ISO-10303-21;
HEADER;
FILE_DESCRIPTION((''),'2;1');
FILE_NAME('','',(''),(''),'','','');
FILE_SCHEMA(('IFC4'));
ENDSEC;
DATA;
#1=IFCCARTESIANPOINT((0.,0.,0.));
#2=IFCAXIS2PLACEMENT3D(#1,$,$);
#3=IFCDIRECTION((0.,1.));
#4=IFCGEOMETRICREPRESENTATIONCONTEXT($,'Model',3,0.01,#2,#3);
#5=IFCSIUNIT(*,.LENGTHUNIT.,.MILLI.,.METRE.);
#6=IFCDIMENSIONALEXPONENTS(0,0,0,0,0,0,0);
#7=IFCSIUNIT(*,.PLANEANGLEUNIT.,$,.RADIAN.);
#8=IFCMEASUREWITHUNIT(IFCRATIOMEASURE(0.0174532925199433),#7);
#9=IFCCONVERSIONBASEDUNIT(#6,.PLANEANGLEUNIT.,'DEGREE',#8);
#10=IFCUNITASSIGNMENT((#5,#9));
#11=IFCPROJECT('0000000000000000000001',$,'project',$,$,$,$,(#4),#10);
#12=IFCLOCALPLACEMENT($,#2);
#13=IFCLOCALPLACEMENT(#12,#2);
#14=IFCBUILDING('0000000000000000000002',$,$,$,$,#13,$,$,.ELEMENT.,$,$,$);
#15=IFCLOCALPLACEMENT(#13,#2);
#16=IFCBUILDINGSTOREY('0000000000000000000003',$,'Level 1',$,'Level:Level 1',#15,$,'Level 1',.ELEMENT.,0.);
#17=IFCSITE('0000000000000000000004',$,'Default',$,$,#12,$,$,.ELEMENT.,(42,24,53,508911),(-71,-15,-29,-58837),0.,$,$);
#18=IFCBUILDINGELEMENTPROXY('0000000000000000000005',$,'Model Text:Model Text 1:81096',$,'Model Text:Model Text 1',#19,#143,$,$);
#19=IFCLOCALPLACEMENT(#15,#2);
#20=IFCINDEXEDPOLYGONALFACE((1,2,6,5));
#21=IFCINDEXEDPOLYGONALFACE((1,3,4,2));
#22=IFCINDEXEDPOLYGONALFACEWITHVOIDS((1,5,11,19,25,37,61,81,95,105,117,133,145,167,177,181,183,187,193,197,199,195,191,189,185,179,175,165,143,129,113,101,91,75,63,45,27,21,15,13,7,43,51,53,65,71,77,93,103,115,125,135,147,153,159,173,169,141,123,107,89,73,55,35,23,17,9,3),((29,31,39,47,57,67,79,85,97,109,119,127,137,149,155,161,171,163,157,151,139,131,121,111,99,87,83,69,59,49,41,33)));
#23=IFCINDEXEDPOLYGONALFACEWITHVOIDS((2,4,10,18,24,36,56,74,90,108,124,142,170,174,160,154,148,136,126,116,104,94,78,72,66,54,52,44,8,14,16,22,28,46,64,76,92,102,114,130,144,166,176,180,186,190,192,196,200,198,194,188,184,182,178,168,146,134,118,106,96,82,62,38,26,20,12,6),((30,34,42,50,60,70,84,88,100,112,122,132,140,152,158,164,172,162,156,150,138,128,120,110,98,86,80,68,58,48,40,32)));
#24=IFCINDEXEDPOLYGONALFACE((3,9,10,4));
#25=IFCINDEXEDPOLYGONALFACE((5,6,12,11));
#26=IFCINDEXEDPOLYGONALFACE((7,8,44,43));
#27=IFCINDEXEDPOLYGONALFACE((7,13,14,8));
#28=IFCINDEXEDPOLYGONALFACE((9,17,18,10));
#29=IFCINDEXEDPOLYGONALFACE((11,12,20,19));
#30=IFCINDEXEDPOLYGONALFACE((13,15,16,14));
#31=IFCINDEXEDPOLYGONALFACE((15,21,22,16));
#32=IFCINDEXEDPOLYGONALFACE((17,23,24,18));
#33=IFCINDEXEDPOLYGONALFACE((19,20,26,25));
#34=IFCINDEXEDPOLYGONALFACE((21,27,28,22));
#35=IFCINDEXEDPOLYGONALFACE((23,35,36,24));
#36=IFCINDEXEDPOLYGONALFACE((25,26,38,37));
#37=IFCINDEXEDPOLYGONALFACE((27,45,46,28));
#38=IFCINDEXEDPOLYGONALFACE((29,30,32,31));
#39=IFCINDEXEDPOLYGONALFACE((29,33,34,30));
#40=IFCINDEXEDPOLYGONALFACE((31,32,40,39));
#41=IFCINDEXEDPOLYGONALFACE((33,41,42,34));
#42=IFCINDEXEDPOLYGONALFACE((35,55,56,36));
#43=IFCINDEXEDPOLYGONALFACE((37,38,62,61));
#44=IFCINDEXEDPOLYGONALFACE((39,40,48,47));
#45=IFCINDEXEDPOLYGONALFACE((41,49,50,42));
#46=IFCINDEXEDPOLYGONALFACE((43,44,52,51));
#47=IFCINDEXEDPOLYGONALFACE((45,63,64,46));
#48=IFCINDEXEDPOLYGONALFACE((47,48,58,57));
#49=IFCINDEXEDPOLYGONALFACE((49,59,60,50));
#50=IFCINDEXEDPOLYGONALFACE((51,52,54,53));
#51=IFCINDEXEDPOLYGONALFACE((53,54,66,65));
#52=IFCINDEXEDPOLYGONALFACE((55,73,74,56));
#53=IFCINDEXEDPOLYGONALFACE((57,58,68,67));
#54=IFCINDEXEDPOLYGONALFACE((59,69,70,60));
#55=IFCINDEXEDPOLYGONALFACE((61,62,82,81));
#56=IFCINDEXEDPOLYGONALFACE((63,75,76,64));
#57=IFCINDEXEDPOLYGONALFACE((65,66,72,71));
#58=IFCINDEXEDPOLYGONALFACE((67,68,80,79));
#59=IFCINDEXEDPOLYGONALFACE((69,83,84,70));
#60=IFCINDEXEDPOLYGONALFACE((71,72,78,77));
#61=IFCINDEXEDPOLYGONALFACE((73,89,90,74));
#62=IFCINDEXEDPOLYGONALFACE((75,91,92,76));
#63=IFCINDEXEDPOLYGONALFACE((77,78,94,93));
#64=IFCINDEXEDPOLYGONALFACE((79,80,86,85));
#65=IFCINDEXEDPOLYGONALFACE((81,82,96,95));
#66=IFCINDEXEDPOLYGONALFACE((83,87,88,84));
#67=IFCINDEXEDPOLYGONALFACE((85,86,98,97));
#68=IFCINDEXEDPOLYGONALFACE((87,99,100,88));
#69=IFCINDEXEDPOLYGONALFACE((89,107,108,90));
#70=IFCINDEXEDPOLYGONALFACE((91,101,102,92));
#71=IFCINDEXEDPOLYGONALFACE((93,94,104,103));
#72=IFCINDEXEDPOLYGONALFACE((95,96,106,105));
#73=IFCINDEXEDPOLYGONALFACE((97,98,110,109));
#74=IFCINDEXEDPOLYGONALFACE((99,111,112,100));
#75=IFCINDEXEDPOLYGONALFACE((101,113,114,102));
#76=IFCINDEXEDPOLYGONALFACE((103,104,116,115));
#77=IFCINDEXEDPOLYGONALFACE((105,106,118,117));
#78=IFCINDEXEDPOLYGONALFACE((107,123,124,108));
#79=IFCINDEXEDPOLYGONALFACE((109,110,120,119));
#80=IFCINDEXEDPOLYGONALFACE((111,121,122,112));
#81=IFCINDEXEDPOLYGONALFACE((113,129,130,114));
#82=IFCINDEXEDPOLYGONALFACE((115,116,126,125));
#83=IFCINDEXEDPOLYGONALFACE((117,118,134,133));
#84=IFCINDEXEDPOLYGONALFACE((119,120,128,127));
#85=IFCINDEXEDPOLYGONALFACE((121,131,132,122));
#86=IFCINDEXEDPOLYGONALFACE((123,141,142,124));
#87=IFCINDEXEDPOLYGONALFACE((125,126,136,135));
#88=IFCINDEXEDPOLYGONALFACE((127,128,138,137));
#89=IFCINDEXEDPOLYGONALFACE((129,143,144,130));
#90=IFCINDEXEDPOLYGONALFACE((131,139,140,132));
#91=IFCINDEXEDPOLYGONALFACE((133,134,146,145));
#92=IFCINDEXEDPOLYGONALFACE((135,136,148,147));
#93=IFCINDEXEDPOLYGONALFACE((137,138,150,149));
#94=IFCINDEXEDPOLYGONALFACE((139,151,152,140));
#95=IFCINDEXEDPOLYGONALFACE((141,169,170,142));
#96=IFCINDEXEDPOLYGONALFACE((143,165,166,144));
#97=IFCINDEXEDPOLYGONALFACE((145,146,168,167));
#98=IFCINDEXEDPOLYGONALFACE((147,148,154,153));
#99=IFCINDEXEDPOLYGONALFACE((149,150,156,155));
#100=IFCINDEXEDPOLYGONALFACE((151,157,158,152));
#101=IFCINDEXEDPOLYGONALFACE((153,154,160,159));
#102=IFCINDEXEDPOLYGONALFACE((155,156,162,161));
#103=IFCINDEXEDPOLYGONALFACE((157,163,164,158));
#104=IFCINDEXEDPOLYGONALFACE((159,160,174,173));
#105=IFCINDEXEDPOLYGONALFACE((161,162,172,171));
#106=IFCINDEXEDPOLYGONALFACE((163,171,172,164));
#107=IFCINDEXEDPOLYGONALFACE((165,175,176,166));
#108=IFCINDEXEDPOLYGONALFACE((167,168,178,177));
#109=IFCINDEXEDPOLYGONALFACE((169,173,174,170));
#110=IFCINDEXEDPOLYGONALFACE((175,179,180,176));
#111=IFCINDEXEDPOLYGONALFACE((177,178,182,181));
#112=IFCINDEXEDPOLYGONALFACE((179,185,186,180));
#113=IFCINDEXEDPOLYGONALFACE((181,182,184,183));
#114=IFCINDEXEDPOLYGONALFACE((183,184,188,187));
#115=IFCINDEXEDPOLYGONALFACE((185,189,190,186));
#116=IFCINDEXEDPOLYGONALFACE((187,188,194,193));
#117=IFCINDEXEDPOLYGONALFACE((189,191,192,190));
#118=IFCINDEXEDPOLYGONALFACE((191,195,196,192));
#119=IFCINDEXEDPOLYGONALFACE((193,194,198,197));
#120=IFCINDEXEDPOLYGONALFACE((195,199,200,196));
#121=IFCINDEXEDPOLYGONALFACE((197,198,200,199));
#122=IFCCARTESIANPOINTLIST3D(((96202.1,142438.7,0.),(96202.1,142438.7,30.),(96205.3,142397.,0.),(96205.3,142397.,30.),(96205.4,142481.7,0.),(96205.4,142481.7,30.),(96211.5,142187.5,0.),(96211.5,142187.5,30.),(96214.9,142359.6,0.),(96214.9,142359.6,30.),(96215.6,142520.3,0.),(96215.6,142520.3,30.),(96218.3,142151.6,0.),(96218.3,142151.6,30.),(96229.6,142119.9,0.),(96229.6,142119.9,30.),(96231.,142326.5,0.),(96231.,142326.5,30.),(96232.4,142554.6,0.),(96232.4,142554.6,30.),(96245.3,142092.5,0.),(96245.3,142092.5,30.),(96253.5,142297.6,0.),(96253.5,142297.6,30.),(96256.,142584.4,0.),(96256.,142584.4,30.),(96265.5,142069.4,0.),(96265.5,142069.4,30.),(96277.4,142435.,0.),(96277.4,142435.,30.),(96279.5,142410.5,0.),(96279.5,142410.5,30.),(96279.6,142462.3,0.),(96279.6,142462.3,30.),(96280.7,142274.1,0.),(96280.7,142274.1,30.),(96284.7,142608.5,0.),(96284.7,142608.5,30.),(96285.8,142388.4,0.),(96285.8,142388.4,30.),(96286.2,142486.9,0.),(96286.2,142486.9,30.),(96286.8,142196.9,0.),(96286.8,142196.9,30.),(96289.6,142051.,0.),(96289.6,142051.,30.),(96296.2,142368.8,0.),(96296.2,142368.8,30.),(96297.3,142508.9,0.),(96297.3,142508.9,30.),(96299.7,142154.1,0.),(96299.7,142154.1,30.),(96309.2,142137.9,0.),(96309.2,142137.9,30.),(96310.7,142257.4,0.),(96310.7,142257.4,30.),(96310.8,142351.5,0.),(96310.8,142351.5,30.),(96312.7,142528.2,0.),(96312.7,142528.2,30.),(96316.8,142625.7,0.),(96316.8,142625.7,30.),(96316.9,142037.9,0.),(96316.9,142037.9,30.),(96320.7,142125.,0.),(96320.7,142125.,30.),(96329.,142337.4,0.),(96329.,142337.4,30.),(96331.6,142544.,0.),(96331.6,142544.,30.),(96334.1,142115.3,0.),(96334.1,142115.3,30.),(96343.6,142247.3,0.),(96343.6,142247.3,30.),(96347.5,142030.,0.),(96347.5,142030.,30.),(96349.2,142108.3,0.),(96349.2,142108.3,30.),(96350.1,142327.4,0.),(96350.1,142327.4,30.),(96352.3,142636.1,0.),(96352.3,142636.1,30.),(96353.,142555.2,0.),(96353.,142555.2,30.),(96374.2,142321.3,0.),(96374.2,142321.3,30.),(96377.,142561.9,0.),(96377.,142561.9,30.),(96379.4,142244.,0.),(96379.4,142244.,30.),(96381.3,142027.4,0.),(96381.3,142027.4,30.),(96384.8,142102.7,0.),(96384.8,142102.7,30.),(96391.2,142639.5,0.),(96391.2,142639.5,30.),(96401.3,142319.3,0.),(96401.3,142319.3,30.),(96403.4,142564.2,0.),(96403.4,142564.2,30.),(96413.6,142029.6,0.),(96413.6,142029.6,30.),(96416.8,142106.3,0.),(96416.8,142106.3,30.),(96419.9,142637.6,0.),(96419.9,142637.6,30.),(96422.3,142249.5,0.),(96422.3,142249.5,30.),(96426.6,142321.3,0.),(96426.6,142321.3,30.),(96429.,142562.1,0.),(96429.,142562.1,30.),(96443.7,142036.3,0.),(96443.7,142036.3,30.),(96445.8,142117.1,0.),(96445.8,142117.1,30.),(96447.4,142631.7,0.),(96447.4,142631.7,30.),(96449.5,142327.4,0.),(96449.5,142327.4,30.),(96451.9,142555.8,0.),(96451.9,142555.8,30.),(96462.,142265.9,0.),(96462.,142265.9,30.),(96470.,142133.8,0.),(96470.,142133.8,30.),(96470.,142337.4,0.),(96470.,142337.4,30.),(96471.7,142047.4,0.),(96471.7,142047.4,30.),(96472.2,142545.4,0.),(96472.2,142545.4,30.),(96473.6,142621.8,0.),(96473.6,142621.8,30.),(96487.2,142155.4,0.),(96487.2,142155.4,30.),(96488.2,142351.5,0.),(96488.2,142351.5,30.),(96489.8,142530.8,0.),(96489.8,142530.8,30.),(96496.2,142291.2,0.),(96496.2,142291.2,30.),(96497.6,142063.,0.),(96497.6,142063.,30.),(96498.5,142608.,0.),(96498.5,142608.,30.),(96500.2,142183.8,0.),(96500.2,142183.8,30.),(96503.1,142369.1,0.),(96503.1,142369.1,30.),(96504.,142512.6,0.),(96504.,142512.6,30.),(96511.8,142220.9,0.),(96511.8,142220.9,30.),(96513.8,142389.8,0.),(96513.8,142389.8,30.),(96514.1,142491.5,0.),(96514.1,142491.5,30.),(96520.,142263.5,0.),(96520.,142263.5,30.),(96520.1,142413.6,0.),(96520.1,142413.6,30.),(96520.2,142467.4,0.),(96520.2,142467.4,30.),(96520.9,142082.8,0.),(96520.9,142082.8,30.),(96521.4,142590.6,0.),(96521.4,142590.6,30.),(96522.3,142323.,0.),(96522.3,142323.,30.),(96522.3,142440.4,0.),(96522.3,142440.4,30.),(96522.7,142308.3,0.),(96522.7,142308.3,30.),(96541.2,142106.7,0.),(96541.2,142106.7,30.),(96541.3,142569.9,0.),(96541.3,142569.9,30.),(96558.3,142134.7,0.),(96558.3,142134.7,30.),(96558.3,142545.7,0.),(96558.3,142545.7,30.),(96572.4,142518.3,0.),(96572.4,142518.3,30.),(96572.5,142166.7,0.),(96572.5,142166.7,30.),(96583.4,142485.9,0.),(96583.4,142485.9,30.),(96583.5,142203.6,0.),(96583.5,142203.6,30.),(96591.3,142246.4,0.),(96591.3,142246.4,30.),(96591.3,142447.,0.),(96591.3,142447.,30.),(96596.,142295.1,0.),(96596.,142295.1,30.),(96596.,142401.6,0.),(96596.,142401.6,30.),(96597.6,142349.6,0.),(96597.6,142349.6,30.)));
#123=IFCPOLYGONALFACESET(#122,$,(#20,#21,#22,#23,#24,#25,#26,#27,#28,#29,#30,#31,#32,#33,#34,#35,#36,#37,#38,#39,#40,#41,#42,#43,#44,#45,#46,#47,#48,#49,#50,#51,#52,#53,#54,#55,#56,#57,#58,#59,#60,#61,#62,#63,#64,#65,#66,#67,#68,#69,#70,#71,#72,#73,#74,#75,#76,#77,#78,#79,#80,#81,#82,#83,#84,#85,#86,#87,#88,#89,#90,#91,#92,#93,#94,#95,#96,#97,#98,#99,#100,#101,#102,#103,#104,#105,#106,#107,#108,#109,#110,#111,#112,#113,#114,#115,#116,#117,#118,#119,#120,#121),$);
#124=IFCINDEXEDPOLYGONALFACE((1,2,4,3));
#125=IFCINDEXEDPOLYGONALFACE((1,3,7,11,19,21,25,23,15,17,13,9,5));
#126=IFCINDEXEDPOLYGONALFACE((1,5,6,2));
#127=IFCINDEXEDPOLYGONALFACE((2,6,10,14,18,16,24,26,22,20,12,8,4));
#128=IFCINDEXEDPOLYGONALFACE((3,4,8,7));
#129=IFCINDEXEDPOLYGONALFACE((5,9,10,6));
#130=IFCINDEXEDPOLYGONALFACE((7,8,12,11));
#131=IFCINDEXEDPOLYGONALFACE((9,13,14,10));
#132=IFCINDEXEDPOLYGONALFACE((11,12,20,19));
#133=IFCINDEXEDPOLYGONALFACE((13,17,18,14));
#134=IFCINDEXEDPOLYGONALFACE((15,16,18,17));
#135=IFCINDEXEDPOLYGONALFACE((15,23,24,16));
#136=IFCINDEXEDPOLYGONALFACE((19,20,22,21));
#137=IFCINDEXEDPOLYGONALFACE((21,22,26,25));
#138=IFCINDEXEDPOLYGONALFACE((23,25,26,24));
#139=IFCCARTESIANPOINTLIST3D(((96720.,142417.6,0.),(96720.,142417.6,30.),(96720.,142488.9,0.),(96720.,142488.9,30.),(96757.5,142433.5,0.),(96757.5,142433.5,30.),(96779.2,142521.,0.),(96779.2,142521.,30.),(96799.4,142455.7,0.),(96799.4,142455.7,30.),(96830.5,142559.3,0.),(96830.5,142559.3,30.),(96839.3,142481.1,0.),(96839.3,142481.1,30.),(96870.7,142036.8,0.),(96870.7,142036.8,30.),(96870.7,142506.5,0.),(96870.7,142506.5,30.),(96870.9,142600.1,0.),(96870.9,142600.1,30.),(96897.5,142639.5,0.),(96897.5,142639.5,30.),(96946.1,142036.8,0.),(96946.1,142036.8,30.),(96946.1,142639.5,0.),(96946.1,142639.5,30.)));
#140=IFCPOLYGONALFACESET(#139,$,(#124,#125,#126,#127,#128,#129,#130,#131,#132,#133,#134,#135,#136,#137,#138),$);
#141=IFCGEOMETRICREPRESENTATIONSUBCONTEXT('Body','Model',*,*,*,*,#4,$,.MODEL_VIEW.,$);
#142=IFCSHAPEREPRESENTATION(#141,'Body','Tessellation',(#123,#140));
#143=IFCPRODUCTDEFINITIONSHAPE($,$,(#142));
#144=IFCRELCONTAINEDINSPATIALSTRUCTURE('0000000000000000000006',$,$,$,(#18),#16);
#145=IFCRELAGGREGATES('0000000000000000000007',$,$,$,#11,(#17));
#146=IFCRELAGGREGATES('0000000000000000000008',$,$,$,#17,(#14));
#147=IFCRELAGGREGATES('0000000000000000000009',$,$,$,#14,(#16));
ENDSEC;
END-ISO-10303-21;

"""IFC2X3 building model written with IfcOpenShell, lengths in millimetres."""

from ifc_helpers import new_model, entity, si_unit, converted_unit, direction, frame, origin, place, context, subcontext, project, spatial, polyline, outline, extrude, element, save


model = new_model("IFC2X3")

# Units and contexts
model_context = context("Model", 3, precision=0.01, world=origin(), true_north=direction((0.0, 1.0)))
body_context = subcontext(model_context, "Body", "Model", "MODEL_VIEW")
ifc_project = project(units=[si_unit("LENGTHUNIT", "METRE", prefix="MILLI"), converted_unit("PLANEANGLEUNIT", "DEGREE", entity("IfcRatioMeasure", 0.0174532925199433), si_unit("PLANEANGLEUNIT", "RADIAN"), dimensions=[0, 0, 0, 0, 0, 0, 0])], contexts=[model_context])

# Site, building, storey
site_placement = place(None, origin())
site = spatial("IfcSite", under=ifc_project, at=site_placement, Name="Default", CompositionType="ELEMENT", RefLatitude=(42, 24, 53, 508911), RefLongitude=(-71, -15, -29, -58837), RefElevation=0.0)
building_placement = place(site_placement, origin())
building = spatial("IfcBuilding", under=site, at=building_placement, CompositionType="ELEMENT")
storey_placement = place(building_placement, origin())
storey = spatial("IfcBuildingStorey", under=building, at=storey_placement, Name="Level 1", ObjectType="Level:Level 1", LongName="Level 1", CompositionType="ELEMENT", Elevation=0.0)

# Building element proxy
proxy_1_placement = place(storey_placement, origin())
element("IfcBuildingElementProxy", 1, at=proxy_1_placement, inside=storey, Name="Model Text:Model Text 1:81096", ObjectType="Model Text:Model Text 1", context=body_context, shape_type="SweptSolid", body=[
    extrude(outline(polyline([(63.9, -207.4), (100.4, -207.4), (133.6, -202.3), (163.4, -191.9), (189.9, -176.3), (212.5, -156.1), (230.5, -131.7), (243.9, -103.1), (252.8, -70.4), (256.6, -38.2), (255.6, -7.4), (249.9, 22.2), (239.4, 50.6), (224.2, 77.1), (204.5, 101.5), (180.3, 123.5), (151.4, 143.4), (117.2, 161.0), (76.6, 176.7), (29.6, 190.4), (-23.7, 202.1), (-75.0, 210.2), (-120.5, 214.0), (-160.2, 213.5), (-194.1, 208.7), (-223.7, 199.9), (-250.5, 187.7), (-274.6, 172.0), (-296.0, 152.8), (-314.2, 130.8), (-328.7, 106.9), (-339.6, 81.0), (-346.9, 53.2), (-350.7, 14.3), (-347.2, -22.5), (-336.2, -57.2), (-317.8, -89.9), (-292.9, -118.6), (-262.4, -141.6), (-226.4, -158.7), (-184.7, -170.0), (-143.2, -174.6), (-104.6, -172.1), (-69.1, -162.4), (-36.5, -145.7), (-8.4, -123.4), (13.6, -97.0), (29.6, -66.5), (39.6, -32.0), (42.2, 11.2), (33.4, 53.3), (14.9, 91.6), (-11.5, 123.1), (3.0, 120.8), (46.6, 109.8), (86.9, 93.9), (121.2, 75.6), (146.7, 57.5), (164.6, 36.5), (176.6, 9.7), (181.8, -20.8), (179.4, -52.9), (167.3, -86.8), (157.6, -100.4), (145.5, -111.8), (130.8, -120.7), (113.0, -127.0), (68.6, -131.7), (63.9, -207.4)]), holes=[polyline([(-126.9, 145.0), (-100.9, 137.9), (-78.7, 127.2), (-60.4, 112.9), (-45.8, 94.9), (-35.4, 74.4), (-29.3, 52.4), (-27.7, 28.8), (-30.4, 3.6), (-37.4, -22.6), (-47.8, -45.2), (-61.6, -64.1), (-78.8, -79.4), (-98.5, -90.5), (-119.8, -97.1), (-142.6, -99.1), (-167.1, -96.6), (-193.5, -89.4), (-216.5, -78.3), (-236.0, -63.4), (-252.1, -44.6), (-264.0, -23.1), (-271.1, 0.0), (-273.3, 24.8), (-270.6, 51.2), (-263.8, 75.9), (-253.4, 97.3), (-239.3, 115.2), (-221.7, 129.8), (-201.2, 140.4), (-178.6, 146.5), (-153.8, 148.0), (-126.9, 145.0)])]), frame((96403.4, 142288.8, 0.0), z_axis=(0.0, 0.0, 1.0), x_axis=(0.185967, -0.982556, 0.0)), (0.0, 0.0, 1.0), 30.0),
    extrude(outline(polyline([(-410.6, -111.6), (192.1, -111.6), (192.1, -63.1), (152.7, -36.4), (111.9, 4.0), (73.6, 55.2), (41.4, 114.4), (-29.8, 114.4), (-13.9, 77.0), (8.3, 35.1), (33.7, -4.8), (59.1, -36.3), (-410.6, -36.3), (-410.6, -111.6)])), frame((96834.5, 142447.4, 0.0), z_axis=(0.0, 0.0, 1.0), x_axis=(0.0, 1.0, 0.0)), (0.0, 0.0, 1.0), 30.0),
])

save(model, "model.ifc")
